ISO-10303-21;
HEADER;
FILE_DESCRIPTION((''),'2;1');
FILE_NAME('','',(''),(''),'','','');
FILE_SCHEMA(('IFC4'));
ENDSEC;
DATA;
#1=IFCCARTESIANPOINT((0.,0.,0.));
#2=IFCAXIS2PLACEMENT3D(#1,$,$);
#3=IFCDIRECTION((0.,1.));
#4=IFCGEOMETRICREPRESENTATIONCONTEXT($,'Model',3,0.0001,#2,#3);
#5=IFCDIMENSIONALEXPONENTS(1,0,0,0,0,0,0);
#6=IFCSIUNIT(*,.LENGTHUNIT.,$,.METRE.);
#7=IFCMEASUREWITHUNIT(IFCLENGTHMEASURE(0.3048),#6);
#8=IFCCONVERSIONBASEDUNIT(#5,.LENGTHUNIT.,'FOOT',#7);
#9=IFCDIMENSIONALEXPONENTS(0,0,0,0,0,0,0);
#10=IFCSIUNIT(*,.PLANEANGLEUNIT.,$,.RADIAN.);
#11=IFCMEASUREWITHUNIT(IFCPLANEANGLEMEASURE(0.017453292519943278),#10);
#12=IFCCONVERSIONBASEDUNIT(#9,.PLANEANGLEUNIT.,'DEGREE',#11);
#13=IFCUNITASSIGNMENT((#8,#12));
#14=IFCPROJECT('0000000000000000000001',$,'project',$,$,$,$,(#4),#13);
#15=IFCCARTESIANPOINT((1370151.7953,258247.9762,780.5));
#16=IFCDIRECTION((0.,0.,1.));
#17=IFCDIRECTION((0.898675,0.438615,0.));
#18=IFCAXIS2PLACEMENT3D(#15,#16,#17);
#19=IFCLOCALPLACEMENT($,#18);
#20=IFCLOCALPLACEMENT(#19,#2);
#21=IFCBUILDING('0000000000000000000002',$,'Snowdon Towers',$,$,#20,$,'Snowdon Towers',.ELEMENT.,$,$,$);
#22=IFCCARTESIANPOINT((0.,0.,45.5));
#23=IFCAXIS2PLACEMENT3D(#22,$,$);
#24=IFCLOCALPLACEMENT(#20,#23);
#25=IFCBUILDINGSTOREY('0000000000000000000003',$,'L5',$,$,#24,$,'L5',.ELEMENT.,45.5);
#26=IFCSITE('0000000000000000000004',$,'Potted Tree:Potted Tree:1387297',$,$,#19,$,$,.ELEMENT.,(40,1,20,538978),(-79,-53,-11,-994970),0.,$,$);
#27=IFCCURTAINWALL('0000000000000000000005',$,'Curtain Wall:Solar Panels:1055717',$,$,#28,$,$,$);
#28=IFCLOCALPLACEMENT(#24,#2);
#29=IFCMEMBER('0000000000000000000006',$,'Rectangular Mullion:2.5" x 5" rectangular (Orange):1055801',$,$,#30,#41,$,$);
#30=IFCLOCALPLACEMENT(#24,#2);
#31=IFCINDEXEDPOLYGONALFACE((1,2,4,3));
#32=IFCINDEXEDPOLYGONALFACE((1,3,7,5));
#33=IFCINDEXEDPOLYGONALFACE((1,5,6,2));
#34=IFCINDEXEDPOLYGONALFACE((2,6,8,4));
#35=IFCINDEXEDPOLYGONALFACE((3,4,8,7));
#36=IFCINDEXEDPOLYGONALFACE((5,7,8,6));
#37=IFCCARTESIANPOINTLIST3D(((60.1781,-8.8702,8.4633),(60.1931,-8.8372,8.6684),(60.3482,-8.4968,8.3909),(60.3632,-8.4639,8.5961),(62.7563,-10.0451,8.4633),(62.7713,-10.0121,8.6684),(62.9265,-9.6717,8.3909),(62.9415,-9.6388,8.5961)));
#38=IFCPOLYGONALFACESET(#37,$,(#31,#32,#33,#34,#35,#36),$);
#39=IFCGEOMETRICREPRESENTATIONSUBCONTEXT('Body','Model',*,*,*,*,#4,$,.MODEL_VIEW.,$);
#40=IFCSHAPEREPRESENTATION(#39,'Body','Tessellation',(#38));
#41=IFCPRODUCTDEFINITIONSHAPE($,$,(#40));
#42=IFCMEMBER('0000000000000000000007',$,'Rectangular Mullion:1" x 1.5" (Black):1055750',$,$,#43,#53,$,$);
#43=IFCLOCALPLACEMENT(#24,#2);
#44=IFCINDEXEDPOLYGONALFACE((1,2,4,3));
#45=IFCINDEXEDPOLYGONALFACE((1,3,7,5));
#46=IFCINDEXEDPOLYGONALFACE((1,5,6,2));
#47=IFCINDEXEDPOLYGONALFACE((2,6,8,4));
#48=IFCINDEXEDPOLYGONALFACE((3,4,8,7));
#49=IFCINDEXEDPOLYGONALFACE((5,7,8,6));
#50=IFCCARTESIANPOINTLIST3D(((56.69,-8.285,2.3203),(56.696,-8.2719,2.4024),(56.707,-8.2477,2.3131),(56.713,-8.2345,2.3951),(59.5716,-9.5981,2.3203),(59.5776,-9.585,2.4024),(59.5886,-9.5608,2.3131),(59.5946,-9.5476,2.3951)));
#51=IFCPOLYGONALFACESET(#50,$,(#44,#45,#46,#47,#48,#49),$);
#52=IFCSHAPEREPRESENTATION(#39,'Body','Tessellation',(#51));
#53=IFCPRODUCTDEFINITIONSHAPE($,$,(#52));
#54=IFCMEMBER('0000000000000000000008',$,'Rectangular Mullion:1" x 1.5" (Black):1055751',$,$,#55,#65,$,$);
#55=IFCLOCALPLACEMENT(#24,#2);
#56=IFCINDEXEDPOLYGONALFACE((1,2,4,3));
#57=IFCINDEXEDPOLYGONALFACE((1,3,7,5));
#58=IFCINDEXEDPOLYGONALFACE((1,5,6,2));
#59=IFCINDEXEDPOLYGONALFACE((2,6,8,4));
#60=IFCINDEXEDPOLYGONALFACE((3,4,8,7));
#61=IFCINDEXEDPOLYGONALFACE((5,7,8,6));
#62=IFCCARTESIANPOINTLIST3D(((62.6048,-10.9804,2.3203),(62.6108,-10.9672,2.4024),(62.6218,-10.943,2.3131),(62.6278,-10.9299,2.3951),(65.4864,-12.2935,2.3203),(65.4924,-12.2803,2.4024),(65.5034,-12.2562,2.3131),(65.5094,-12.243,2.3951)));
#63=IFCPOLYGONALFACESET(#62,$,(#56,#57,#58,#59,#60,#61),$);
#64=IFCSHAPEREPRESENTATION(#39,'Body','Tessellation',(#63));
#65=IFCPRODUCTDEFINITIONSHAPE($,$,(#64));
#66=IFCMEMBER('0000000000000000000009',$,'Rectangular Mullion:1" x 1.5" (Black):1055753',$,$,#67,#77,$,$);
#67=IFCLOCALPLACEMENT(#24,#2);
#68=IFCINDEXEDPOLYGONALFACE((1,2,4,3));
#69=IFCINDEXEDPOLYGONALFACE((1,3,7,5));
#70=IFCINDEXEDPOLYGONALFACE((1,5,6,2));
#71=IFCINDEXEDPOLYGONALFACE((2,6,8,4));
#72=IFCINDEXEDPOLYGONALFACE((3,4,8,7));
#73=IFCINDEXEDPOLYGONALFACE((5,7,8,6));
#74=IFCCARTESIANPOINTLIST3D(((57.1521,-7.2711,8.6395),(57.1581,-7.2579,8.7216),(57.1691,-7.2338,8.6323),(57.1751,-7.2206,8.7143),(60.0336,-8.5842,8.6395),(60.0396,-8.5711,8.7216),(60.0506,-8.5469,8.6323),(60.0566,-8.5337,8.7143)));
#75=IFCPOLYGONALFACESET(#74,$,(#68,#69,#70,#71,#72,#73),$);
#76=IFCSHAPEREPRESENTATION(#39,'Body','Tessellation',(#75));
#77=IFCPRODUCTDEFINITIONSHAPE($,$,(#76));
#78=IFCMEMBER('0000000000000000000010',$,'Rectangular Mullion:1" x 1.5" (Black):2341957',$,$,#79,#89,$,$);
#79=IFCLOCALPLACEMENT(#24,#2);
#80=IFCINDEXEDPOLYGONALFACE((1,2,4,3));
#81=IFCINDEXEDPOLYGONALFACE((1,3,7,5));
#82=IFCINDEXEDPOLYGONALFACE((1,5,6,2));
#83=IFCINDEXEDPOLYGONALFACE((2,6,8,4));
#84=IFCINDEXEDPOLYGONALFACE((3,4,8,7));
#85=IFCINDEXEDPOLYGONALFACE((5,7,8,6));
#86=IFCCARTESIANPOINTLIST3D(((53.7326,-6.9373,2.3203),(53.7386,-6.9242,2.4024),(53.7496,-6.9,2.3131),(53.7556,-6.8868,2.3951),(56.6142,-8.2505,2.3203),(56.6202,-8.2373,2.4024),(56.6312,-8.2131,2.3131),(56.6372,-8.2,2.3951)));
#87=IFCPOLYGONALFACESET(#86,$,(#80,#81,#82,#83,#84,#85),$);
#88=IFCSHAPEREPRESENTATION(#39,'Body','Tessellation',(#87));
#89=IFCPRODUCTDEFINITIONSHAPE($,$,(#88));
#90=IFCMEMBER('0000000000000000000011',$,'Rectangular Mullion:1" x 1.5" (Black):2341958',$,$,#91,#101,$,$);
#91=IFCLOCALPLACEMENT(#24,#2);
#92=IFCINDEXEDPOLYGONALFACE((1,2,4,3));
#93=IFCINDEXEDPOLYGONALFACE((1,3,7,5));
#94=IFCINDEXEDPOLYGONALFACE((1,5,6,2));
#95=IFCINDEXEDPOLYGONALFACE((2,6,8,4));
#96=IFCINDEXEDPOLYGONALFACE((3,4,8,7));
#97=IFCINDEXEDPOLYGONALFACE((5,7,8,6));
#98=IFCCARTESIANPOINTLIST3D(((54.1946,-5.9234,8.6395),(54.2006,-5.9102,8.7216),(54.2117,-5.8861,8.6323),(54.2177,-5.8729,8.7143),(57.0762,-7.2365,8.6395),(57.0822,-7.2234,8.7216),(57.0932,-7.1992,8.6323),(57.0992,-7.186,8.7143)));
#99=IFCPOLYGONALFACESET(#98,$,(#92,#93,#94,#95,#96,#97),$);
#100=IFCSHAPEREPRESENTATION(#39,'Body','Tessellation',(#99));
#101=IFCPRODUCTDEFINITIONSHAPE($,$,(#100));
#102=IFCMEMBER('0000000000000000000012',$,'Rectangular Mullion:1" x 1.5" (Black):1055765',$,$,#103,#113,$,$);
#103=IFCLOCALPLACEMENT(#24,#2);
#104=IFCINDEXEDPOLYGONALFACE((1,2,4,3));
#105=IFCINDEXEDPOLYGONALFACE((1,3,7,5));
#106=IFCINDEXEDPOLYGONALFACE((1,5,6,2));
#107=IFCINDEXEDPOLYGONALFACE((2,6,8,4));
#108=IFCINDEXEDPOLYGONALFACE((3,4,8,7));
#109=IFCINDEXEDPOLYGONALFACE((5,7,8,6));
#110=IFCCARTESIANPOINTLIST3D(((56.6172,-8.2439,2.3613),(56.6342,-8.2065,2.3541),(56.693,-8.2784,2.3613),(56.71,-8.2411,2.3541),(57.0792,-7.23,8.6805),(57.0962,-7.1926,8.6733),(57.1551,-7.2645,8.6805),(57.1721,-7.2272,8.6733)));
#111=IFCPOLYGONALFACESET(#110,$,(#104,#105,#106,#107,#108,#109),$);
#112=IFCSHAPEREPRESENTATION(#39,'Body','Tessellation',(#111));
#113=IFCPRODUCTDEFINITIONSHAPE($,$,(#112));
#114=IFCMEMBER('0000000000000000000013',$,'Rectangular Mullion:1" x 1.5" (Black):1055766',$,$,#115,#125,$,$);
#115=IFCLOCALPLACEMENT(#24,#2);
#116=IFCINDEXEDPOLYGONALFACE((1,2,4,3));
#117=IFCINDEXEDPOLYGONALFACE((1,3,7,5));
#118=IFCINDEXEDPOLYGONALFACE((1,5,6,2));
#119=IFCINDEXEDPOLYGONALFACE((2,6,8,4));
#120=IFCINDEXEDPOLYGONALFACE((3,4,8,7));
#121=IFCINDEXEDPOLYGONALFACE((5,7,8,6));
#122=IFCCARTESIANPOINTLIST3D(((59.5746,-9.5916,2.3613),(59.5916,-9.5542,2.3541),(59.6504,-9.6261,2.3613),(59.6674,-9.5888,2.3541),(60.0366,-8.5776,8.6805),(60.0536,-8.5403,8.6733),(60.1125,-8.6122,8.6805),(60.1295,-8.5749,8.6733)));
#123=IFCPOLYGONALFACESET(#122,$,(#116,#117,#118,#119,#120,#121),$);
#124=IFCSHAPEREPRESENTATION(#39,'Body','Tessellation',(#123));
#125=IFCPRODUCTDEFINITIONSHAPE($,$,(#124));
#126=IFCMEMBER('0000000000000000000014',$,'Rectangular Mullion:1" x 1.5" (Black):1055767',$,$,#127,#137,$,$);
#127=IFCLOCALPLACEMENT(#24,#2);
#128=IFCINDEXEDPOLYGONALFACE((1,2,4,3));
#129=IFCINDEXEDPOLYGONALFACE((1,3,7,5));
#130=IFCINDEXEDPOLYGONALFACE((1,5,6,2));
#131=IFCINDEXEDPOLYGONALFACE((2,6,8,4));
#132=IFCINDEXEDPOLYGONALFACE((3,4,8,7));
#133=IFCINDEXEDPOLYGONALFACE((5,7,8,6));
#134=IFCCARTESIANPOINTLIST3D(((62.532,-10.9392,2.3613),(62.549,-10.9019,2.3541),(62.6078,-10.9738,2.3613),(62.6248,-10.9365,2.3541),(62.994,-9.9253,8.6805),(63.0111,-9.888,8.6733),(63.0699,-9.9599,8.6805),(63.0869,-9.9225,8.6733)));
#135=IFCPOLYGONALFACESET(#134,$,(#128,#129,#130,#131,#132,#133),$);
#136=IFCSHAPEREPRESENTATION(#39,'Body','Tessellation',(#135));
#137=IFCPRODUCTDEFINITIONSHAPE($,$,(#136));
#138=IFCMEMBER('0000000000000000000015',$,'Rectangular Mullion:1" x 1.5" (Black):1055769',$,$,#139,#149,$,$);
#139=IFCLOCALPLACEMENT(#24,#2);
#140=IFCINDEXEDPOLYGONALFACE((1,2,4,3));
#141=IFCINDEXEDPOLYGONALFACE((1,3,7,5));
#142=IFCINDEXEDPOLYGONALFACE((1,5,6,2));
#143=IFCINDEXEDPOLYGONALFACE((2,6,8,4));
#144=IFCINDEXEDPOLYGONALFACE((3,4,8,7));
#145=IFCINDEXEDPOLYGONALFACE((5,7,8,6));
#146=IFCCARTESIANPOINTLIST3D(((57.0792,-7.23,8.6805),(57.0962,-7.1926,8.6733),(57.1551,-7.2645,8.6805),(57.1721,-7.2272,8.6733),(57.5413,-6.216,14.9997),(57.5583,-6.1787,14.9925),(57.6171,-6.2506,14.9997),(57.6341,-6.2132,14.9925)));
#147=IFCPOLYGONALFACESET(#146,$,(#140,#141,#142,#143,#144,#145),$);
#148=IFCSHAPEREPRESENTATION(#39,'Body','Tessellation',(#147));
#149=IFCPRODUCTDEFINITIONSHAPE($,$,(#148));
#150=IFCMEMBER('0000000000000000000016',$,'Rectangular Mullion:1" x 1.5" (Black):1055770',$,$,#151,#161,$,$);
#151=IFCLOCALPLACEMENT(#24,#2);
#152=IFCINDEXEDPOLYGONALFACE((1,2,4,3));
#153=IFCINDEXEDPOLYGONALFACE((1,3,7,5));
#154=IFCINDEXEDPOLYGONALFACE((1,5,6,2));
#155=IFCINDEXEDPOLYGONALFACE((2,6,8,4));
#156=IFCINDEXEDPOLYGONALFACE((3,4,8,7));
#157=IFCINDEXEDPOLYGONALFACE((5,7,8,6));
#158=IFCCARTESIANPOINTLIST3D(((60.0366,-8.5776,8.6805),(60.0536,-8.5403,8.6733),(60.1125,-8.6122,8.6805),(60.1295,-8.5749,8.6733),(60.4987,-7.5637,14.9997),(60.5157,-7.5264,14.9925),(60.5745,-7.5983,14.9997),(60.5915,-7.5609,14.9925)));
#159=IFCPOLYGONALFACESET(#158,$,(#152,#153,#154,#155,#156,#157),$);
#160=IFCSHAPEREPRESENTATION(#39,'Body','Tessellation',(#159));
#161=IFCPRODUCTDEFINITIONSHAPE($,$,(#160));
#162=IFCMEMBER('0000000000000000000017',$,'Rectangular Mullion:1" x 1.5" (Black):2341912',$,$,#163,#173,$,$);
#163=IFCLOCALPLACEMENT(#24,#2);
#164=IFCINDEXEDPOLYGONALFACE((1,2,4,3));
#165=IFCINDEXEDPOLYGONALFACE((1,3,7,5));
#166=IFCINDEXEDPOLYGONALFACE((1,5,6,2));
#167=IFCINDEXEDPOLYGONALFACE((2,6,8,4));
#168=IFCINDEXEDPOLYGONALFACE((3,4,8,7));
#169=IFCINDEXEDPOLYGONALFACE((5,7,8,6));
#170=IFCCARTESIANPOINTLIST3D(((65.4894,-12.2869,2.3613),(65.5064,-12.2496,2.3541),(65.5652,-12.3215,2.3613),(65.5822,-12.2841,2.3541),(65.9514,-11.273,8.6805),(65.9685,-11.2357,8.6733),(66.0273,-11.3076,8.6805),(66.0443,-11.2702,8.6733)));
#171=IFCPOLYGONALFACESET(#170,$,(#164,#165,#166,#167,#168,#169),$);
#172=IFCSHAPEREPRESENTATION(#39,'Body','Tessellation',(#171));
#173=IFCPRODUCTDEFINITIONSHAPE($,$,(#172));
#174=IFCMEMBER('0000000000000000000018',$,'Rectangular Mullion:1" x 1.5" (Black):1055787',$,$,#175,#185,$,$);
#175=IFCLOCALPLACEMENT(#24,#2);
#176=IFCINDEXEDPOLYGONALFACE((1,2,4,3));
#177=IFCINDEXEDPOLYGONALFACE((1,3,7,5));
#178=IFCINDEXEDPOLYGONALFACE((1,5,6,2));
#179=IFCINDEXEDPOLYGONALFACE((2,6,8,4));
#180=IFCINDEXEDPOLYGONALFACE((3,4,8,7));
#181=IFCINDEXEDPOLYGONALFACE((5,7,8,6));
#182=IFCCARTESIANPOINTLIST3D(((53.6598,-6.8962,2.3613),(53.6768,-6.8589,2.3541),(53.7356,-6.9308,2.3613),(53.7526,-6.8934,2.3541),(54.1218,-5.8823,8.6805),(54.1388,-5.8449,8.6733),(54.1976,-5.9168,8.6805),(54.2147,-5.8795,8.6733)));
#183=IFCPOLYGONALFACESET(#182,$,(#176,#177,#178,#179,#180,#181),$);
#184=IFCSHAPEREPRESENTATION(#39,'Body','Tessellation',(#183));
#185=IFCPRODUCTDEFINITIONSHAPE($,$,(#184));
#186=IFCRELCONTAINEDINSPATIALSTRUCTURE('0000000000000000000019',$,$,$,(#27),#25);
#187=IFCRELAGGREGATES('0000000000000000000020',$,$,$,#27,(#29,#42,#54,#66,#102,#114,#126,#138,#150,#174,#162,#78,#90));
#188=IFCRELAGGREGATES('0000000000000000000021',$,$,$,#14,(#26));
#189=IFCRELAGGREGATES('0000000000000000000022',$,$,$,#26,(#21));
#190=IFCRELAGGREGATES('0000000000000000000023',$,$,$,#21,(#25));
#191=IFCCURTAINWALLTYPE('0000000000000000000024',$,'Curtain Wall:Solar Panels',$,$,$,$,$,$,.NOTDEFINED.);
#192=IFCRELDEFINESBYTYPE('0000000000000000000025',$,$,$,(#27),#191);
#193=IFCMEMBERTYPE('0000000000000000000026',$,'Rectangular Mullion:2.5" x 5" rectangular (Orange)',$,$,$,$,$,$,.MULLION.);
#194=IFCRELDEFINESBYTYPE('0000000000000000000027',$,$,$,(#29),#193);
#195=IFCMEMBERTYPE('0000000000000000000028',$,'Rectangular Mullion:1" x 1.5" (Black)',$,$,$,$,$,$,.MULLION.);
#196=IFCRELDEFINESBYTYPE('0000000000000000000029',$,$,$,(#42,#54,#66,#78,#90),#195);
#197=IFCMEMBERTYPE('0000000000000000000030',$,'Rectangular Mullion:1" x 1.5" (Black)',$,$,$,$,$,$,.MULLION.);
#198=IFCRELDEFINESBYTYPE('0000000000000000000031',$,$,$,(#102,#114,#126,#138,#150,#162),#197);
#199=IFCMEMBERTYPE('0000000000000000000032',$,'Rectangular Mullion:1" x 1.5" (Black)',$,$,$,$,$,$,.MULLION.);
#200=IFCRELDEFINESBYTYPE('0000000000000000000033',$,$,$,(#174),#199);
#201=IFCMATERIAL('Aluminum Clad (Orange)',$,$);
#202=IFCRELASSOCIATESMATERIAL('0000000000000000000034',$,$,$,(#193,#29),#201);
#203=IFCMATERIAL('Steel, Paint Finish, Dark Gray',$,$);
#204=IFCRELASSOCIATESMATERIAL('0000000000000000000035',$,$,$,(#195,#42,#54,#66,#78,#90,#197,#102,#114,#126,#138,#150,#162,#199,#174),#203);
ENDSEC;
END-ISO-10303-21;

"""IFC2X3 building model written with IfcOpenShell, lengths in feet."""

from ifc_helpers import new_model, entity, si_unit, converted_unit, direction, frame, frame_2d, origin, origin_2d_with_axis, place, context, subcontext, project, spatial, rectangle, extrude, source, transform, mapped, material, type_object, type_shapes, element, aggregate, save


model = new_model("IFC2X3")

# Units and contexts
model_context = context("Model", 3, precision=0.0001, world=origin(), true_north=direction((0.0, 1.0)))
body_context = subcontext(model_context, "Body", "Model", "MODEL_VIEW")
ifc_project = project(units=[converted_unit("LENGTHUNIT", "FOOT", entity("IfcLengthMeasure", 0.3048), si_unit("LENGTHUNIT", "METRE"), dimensions=[1, 0, 0, 0, 0, 0, 0]), converted_unit("PLANEANGLEUNIT", "DEGREE", entity("IfcPlaneAngleMeasure", 0.017453292519943278), si_unit("PLANEANGLEUNIT", "RADIAN"), dimensions=[0, 0, 0, 0, 0, 0, 0])], contexts=[model_context])

# Site, building, storey
site_placement = place(None, frame((1370151.7953, 258247.9762, 780.5), z_axis=(0.0, 0.0, 1.0), x_axis=(0.898675, 0.438615, 0.0)))
site = spatial("IfcSite", under=ifc_project, at=site_placement, Name="Potted Tree:Potted Tree:1387297", CompositionType="ELEMENT", RefLatitude=(40, 1, 20, 538978), RefLongitude=(-79, -53, -11, -994970), RefElevation=0.0)
building_placement = place(site_placement, origin())
building = spatial("IfcBuilding", under=site, at=building_placement, Name="Snowdon Towers", LongName="Snowdon Towers", CompositionType="ELEMENT")
storey_placement = place(building_placement, frame((0.0, 0.0, 45.5)))
storey = spatial("IfcBuildingStorey", under=building, at=storey_placement, Name="L5", LongName="L5", CompositionType="ELEMENT", Elevation=45.5)

# Curtain wall, members
curtain_wall_type = type_object("IfcCurtainWallType", Name="Curtain Wall:Solar Panels", PredefinedType="NOTDEFINED")
curtain_wall_placement = place(storey_placement, frame((0.0, 0.0, -45.5)))
curtain_wall = element("IfcCurtainWall", 1, at=curtain_wall_placement, inside=storey, type_object=curtain_wall_type, Name="Curtain Wall:Solar Panels:1055717")
ifc_material_1 = material(Name="Aluminum Clad (Orange)")
member_type_1 = type_object("IfcMemberType", Name="Rectangular Mullion:2.5\" x 5\" rectangular (Orange)", PredefinedType="MULLION", material=ifc_material_1)
shared_shape_1 = source(origin(), body_context, "Body", "SweptSolid", [
    extrude(rectangle(XDim=0.2083, YDim=0.4167, at=frame_2d((0.0, 0.0), x_axis=(1.0, 0.0))), frame((-0.1042, 0.0, -2.8333), z_axis=(0.0, 0.0, 1.0), x_axis=(-1.0, 0.0, 0.0)), (0.0, 0.0, 1.0), 2.8333),
])
type_shapes(member_type_1, [shared_shape_1])
member_1_placement = place(curtain_wall_placement, frame((62.8564, -9.8254, 54.1323), z_axis=(0.909972, -0.414671, 0.0), x_axis=(0.072007, 0.158015, 0.984808)))
member_1 = element("IfcMember", 2, at=member_1_placement, type_object=member_type_1, material=ifc_material_1, Name="Rectangular Mullion:2.5\" x 5\" rectangular (Orange):1055801", context=body_context, shape_type="MappedRepresentation", body=[
    mapped(shared_shape_1, transform((0.0, 0.0, 0.0), scale=1.0)),
])
ifc_material_2 = material(Name="Steel, Paint Finish, Dark Gray")
member_type_2 = type_object("IfcMemberType", Name="Rectangular Mullion:1\" x 1.5\" (Black)", PredefinedType="MULLION", material=ifc_material_2)
shared_shape_2 = source(origin(), body_context, "Body", "SweptSolid", [
    extrude(rectangle(XDim=0.0833, YDim=0.0417, at=origin_2d_with_axis()), frame((0.0, 0.0208, -3.1667), z_axis=(0.0, 0.0, 1.0), x_axis=(-1.0, 0.0, 0.0)), (0.0, 0.0, 1.0), 3.1667),
])
type_shapes(member_type_2, [shared_shape_2])
member_2_placement = place(curtain_wall_placement, frame((59.5916, -9.5542, 47.8541), z_axis=(0.909972, -0.414671, 0.0), x_axis=(0.072007, 0.158015, 0.984808)))
member_2 = element("IfcMember", 3, at=member_2_placement, type_object=member_type_2, material=ifc_material_2, Name="Rectangular Mullion:1\" x 1.5\" (Black):1055750", context=body_context, shape_type="MappedRepresentation", body=[
    mapped(shared_shape_2, transform((0.0, 0.0, 0.0), scale=1.0)),
])
member_3_placement = place(curtain_wall_placement, frame((65.5064, -12.2496, 47.8541), z_axis=(0.909972, -0.414671, 0.0), x_axis=(0.072007, 0.158015, 0.984808)))
member_3 = element("IfcMember", 4, at=member_3_placement, type_object=member_type_2, material=ifc_material_2, Name="Rectangular Mullion:1\" x 1.5\" (Black):1055751", context=body_context, shape_type="MappedRepresentation", body=[
    mapped(shared_shape_2, transform((0.0, 0.0, 0.0), scale=1.0)),
])
member_4_placement = place(curtain_wall_placement, frame((60.0536, -8.5403, 54.1733), z_axis=(0.909972, -0.414671, 0.0), x_axis=(0.072007, 0.158015, 0.984808)))
member_4 = element("IfcMember", 5, at=member_4_placement, type_object=member_type_2, material=ifc_material_2, Name="Rectangular Mullion:1\" x 1.5\" (Black):1055753", context=body_context, shape_type="MappedRepresentation", body=[
    mapped(shared_shape_2, transform((0.0, 0.0, 0.0), scale=1.0)),
])
member_5_placement = place(curtain_wall_placement, frame((56.6342, -8.2065, 47.8541), z_axis=(0.909972, -0.414671, 0.0), x_axis=(0.072007, 0.158015, 0.984808)))
member_5 = element("IfcMember", 6, at=member_5_placement, type_object=member_type_2, material=ifc_material_2, Name="Rectangular Mullion:1\" x 1.5\" (Black):2341957", context=body_context, shape_type="MappedRepresentation", body=[
    mapped(shared_shape_2, transform((0.0, 0.0, 0.0), scale=1.0)),
])
member_6_placement = place(curtain_wall_placement, frame((57.0962, -7.1926, 54.1733), z_axis=(0.909972, -0.414671, 0.0), x_axis=(0.072007, 0.158015, 0.984808)))
member_6 = element("IfcMember", 7, at=member_6_placement, type_object=member_type_2, material=ifc_material_2, Name="Rectangular Mullion:1\" x 1.5\" (Black):2341958", context=body_context, shape_type="MappedRepresentation", body=[
    mapped(shared_shape_2, transform((0.0, 0.0, 0.0), scale=1.0)),
])
member_type_3 = type_object("IfcMemberType", Name="Rectangular Mullion:1\" x 1.5\" (Black)", PredefinedType="MULLION", material=ifc_material_2)
shared_shape_3 = source(origin(), body_context, "Body", "SweptSolid", [
    extrude(rectangle(XDim=0.0833, YDim=0.0417, at=origin_2d_with_axis()), frame((0.0, 0.0208, -6.4167), z_axis=(0.0, 0.0, 1.0), x_axis=(-1.0, 0.0, 0.0)), (0.0, 0.0, 1.0), 6.4167),
])
type_shapes(member_type_3, [shared_shape_3])
member_7_placement = place(curtain_wall_placement, frame((56.6721, -8.2238, 47.8541), z_axis=(-0.072007, -0.158015, -0.984808), x_axis=(0.909972, -0.414671, 0.0)))
member_7 = element("IfcMember", 8, at=member_7_placement, type_object=member_type_3, material=ifc_material_2, Name="Rectangular Mullion:1\" x 1.5\" (Black):1055765", context=body_context, shape_type="MappedRepresentation", body=[
    mapped(shared_shape_3, transform((0.0, 0.0, 0.0), scale=1.0)),
])
member_8_placement = place(curtain_wall_placement, frame((59.6295, -9.5715, 47.8541), z_axis=(-0.072007, -0.158015, -0.984808), x_axis=(0.909972, -0.414671, 0.0)))
member_8 = element("IfcMember", 9, at=member_8_placement, type_object=member_type_3, material=ifc_material_2, Name="Rectangular Mullion:1\" x 1.5\" (Black):1055766", context=body_context, shape_type="MappedRepresentation", body=[
    mapped(shared_shape_3, transform((0.0, 0.0, 0.0), scale=1.0)),
])
member_9_placement = place(curtain_wall_placement, frame((62.5869, -10.9192, 47.8541), z_axis=(-0.072007, -0.158015, -0.984808), x_axis=(0.909972, -0.414671, 0.0)))
member_9 = element("IfcMember", 10, at=member_9_placement, type_object=member_type_3, material=ifc_material_2, Name="Rectangular Mullion:1\" x 1.5\" (Black):1055767", context=body_context, shape_type="MappedRepresentation", body=[
    mapped(shared_shape_3, transform((0.0, 0.0, 0.0), scale=1.0)),
])
member_10_placement = place(curtain_wall_placement, frame((57.1342, -7.2099, 54.1733), z_axis=(-0.072007, -0.158015, -0.984808), x_axis=(0.909972, -0.414671, 0.0)))
member_10 = element("IfcMember", 11, at=member_10_placement, type_object=member_type_3, material=ifc_material_2, Name="Rectangular Mullion:1\" x 1.5\" (Black):1055769", context=body_context, shape_type="MappedRepresentation", body=[
    mapped(shared_shape_3, transform((0.0, 0.0, 0.0), scale=1.0)),
])
member_11_placement = place(curtain_wall_placement, frame((60.0916, -8.5576, 54.1733), z_axis=(-0.072007, -0.158015, -0.984808), x_axis=(0.909972, -0.414671, 0.0)))
member_11 = element("IfcMember", 12, at=member_11_placement, type_object=member_type_3, material=ifc_material_2, Name="Rectangular Mullion:1\" x 1.5\" (Black):1055770", context=body_context, shape_type="MappedRepresentation", body=[
    mapped(shared_shape_3, transform((0.0, 0.0, 0.0), scale=1.0)),
])
member_12_placement = place(curtain_wall_placement, frame((65.5443, -12.2669, 47.8541), z_axis=(-0.072007, -0.158015, -0.984808), x_axis=(0.909972, -0.414671, 0.0)))
member_12 = element("IfcMember", 13, at=member_12_placement, type_object=member_type_3, material=ifc_material_2, Name="Rectangular Mullion:1\" x 1.5\" (Black):2341912", context=body_context, shape_type="MappedRepresentation", body=[
    mapped(shared_shape_3, transform((0.0, 0.0, 0.0), scale=1.0)),
])
member_type_4 = type_object("IfcMemberType", Name="Rectangular Mullion:1\" x 1.5\" (Black)", PredefinedType="MULLION", material=ifc_material_2)
shared_shape_4 = source(origin(), body_context, "Body", "SweptSolid", [
    extrude(rectangle(XDim=0.0833, YDim=0.0417, at=frame_2d((0.0, 0.0), x_axis=(1.0, 0.0))), frame((-0.0417, 0.0208, -6.4167), z_axis=(0.0, 0.0, 1.0), x_axis=(-1.0, 0.0, 0.0)), (0.0, 0.0, 1.0), 6.4167),
])
type_shapes(member_type_4, [shared_shape_4])
member_13_placement = place(curtain_wall_placement, frame((54.1388, -5.8449, 54.1733), z_axis=(0.072007, 0.158015, 0.984808), x_axis=(-0.909972, 0.414671, 0.0)))
member_13 = element("IfcMember", 14, at=member_13_placement, type_object=member_type_4, material=ifc_material_2, Name="Rectangular Mullion:1\" x 1.5\" (Black):1055787", context=body_context, shape_type="MappedRepresentation", body=[
    mapped(shared_shape_4, transform((0.0, 0.0, 0.0), scale=1.0)),
])
aggregate(curtain_wall, [member_1, member_2, member_3, member_4, member_7, member_8, member_9, member_10, member_11, member_13, member_12, member_5, member_6])

save(model, "model.ifc")
